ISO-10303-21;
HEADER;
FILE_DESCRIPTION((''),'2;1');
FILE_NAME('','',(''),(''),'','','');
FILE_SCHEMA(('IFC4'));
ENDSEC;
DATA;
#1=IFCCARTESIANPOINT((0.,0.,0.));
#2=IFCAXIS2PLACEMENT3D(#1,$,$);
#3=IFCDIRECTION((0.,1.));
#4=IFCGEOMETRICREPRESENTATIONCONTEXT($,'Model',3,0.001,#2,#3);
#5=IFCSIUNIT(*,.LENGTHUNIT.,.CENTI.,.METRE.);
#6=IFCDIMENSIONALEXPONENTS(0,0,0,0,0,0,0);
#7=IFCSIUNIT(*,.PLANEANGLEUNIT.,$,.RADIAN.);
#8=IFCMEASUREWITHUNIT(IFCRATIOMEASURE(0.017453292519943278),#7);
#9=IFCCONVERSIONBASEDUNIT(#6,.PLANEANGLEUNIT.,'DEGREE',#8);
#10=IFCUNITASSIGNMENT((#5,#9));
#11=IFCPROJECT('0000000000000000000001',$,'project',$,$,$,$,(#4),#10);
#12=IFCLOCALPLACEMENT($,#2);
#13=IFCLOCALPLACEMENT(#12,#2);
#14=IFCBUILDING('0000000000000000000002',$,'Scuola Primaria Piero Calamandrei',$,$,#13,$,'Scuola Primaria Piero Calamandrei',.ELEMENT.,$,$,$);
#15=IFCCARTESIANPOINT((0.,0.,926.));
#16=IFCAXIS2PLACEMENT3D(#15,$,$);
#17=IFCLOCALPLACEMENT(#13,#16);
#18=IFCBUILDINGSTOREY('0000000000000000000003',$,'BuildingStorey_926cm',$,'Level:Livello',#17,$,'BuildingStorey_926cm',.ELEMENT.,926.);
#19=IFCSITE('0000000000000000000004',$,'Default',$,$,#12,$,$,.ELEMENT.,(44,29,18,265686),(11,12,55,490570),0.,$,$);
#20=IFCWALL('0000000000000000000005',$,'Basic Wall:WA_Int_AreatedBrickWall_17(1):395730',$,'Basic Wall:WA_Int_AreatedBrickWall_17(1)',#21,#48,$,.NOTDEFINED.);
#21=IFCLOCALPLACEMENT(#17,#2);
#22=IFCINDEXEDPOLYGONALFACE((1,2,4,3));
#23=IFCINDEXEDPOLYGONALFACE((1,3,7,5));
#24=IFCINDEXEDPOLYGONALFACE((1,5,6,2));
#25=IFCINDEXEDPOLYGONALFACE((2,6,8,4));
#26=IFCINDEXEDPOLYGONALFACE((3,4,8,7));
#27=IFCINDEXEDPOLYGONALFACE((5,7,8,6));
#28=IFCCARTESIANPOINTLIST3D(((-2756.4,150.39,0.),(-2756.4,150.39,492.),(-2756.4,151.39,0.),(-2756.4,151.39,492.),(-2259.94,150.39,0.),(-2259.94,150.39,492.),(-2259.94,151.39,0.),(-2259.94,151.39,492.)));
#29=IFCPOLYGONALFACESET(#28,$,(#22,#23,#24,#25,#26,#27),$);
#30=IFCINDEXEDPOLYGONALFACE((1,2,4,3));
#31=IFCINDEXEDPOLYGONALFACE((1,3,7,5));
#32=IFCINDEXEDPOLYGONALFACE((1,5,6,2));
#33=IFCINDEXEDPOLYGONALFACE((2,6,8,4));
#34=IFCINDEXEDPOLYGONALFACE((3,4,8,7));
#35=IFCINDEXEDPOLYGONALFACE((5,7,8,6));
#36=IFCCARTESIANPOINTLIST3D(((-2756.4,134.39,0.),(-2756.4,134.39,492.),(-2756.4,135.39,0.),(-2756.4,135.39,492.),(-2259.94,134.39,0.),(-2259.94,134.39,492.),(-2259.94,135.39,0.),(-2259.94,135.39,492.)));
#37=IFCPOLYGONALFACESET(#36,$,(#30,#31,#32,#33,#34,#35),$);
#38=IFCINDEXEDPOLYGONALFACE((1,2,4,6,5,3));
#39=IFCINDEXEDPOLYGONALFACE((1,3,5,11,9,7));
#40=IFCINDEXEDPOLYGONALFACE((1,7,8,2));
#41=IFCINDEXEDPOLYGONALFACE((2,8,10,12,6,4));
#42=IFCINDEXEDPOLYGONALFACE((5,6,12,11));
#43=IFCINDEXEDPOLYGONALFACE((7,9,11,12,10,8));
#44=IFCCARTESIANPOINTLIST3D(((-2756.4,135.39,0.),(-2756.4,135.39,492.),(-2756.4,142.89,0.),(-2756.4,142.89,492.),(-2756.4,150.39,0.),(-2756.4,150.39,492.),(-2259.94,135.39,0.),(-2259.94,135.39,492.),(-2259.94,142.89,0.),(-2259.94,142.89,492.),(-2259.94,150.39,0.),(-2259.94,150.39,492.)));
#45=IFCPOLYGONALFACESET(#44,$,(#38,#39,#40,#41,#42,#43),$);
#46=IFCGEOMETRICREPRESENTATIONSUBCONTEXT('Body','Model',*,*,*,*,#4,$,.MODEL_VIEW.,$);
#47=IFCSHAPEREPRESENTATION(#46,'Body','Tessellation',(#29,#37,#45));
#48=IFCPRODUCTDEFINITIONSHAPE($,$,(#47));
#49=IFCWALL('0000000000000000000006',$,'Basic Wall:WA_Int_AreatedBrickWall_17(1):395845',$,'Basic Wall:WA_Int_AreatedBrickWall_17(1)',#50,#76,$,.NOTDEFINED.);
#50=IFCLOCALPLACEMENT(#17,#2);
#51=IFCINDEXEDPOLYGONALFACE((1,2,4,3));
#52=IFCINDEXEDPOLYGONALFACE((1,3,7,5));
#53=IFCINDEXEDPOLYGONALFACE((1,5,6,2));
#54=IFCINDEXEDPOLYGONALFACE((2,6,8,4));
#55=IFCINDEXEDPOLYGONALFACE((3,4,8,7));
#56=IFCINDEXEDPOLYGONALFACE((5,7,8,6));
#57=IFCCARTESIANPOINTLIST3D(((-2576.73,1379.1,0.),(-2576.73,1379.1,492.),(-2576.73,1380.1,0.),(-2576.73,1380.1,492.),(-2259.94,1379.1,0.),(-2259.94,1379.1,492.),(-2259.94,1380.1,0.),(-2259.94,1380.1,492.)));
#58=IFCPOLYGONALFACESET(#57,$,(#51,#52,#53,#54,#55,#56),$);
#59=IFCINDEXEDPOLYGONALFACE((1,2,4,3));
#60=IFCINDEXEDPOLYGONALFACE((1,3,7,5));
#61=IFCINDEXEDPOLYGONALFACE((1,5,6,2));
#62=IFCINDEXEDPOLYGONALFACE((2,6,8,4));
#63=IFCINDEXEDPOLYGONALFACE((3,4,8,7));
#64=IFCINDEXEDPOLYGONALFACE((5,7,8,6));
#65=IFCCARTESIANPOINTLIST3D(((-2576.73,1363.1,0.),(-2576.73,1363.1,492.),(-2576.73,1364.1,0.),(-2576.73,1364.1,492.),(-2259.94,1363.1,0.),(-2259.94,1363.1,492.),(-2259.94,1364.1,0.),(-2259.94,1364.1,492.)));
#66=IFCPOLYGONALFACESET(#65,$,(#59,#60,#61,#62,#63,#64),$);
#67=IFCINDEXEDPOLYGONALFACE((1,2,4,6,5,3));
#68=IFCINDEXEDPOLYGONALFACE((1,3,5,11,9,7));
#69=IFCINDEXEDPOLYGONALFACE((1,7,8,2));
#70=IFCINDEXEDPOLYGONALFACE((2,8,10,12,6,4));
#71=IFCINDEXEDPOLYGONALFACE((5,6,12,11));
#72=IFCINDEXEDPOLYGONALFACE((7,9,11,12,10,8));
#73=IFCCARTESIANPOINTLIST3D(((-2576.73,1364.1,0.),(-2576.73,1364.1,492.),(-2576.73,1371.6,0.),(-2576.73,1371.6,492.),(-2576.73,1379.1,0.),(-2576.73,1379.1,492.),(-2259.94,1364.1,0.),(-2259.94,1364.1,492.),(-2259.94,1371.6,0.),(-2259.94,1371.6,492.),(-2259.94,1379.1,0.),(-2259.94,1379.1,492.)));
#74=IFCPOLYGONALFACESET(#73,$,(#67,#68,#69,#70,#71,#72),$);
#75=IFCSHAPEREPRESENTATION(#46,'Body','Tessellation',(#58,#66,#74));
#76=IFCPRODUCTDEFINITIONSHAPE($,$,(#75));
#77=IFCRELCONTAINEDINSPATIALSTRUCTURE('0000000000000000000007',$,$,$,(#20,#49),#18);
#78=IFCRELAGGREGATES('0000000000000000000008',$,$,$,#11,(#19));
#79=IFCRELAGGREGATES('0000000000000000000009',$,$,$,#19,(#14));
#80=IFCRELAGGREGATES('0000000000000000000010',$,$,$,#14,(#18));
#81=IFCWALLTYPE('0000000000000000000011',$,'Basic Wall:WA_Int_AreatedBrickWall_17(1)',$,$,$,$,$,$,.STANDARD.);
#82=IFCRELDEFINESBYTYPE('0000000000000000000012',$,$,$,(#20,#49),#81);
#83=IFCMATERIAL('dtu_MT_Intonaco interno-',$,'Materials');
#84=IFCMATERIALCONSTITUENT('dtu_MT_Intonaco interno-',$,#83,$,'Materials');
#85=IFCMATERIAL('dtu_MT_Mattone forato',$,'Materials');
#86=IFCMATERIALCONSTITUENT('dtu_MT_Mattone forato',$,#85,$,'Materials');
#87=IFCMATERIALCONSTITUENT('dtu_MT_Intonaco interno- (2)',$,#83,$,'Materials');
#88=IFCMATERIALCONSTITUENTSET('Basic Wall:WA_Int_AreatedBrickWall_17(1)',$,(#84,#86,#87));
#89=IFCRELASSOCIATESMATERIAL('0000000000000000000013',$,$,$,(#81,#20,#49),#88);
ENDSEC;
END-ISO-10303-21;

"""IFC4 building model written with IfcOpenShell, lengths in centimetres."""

from ifc_helpers import new_model, entity, si_unit, converted_unit, direction, frame, origin, place, context, subcontext, project, spatial, indexed_curve, outline, extrude, material, constituent, constituent_set, type_object, element, save


model = new_model("IFC4")

# Units and contexts
model_context = context("Model", 3, precision=0.001, world=origin(), true_north=direction((0.0, 1.0)))
body_context = subcontext(model_context, "Body", "Model", "MODEL_VIEW")
ifc_project = project(units=[si_unit("LENGTHUNIT", "METRE", prefix="CENTI"), converted_unit("PLANEANGLEUNIT", "DEGREE", entity("IfcRatioMeasure", 0.017453292519943278), si_unit("PLANEANGLEUNIT", "RADIAN"), dimensions=[0, 0, 0, 0, 0, 0, 0])], contexts=[model_context])

# Site, building, storey
site_placement = place(None, origin())
site = spatial("IfcSite", under=ifc_project, at=site_placement, Name="Default", CompositionType="ELEMENT", RefLatitude=(44, 29, 18, 265686), RefLongitude=(11, 12, 55, 490570), RefElevation=0.0)
building_placement = place(site_placement, origin())
building = spatial("IfcBuilding", under=site, at=building_placement, Name="Scuola Primaria Piero Calamandrei", LongName="Scuola Primaria Piero Calamandrei", CompositionType="ELEMENT")
storey_placement = place(building_placement, frame((0.0, 0.0, 926.0)))
storey = spatial("IfcBuildingStorey", under=building, at=storey_placement, Name="BuildingStorey_926cm", ObjectType="Level:Livello", LongName="BuildingStorey_926cm", CompositionType="ELEMENT", Elevation=926.0)

# Shared definitions
ifc_material_1 = material(Name="dtu_MT_Intonaco interno-", Category="Materials")

# Walls
ifc_constituent_1 = constituent(ifc_material_1, Name="dtu_MT_Intonaco interno-", Category="Materials")
ifc_material_2 = material(Name="dtu_MT_Mattone forato", Category="Materials")
ifc_constituent_2 = constituent(ifc_material_2, Name="dtu_MT_Mattone forato", Category="Materials")
ifc_constituent_3 = constituent(ifc_material_1, Name="dtu_MT_Intonaco interno- (2)", Category="Materials")
ifc_constituent_set_1 = constituent_set(constituents=[ifc_constituent_1, ifc_constituent_2, ifc_constituent_3], Name="Basic Wall:WA_Int_AreatedBrickWall_17(1)")
wall_type_1 = type_object("IfcWallType", Name="Basic Wall:WA_Int_AreatedBrickWall_17(1)", PredefinedType="STANDARD", material=ifc_constituent_set_1)
wall_1_placement = place(storey_placement, frame((-2259.94, 142.89, 0.0), z_axis=(0.0, 0.0, 1.0), x_axis=(-1.0, 0.0, 0.0)))
element("IfcWall", 1, at=wall_1_placement, inside=storey, type_object=wall_type_1, material=ifc_constituent_set_1, Name="Basic Wall:WA_Int_AreatedBrickWall_17(1):395730", ObjectType="Basic Wall:WA_Int_AreatedBrickWall_17(1)", PredefinedType="NOTDEFINED", context=body_context, shape_type="SweptSolid", body=[
    extrude(outline(indexed_curve([(-0.5, -248.23), (0.5, -248.23), (0.5, 248.23), (-0.5, 248.23), (-0.5, -248.23)], self_intersect=False)), frame((248.23, -8.0, 0.0), z_axis=(0.0, 0.0, 1.0), x_axis=(0.0, 1.0, 0.0)), (0.0, 0.0, 1.0), 492.0),
    extrude(outline(indexed_curve([(-0.5, -248.23), (0.5, -248.23), (0.5, 248.23), (-0.5, 248.23), (-0.5, -248.23)], self_intersect=False)), frame((248.23, 8.0, 0.0), z_axis=(0.0, 0.0, 1.0), x_axis=(0.0, -1.0, 0.0)), (0.0, 0.0, 1.0), 492.0),
    extrude(outline(indexed_curve([(-248.23, -7.5), (248.23, -7.5), (248.23, 0.0), (248.23, 7.5), (-248.23, 7.5), (-248.23, 0.0), (-248.23, -7.5)], self_intersect=False)), frame((248.23, 0.0, 0.0)), (0.0, 0.0, 1.0), 492.0),
])
wall_2_placement = place(storey_placement, frame((-2259.94, 1371.6, 0.0), z_axis=(0.0, 0.0, 1.0), x_axis=(-1.0, 0.0, 0.0)))
element("IfcWall", 2, at=wall_2_placement, inside=storey, type_object=wall_type_1, material=ifc_constituent_set_1, Name="Basic Wall:WA_Int_AreatedBrickWall_17(1):395845", ObjectType="Basic Wall:WA_Int_AreatedBrickWall_17(1)", PredefinedType="NOTDEFINED", context=body_context, shape_type="SweptSolid", body=[
    extrude(outline(indexed_curve([(-0.5, -158.4), (0.5, -158.4), (0.5, 158.4), (-0.5, 158.4), (-0.5, -158.4)], self_intersect=False)), frame((158.4, -8.0, 0.0), z_axis=(0.0, 0.0, 1.0), x_axis=(0.0, 1.0, 0.0)), (0.0, 0.0, 1.0), 492.0),
    extrude(outline(indexed_curve([(-0.5, -158.4), (0.5, -158.4), (0.5, 158.4), (-0.5, 158.4), (-0.5, -158.4)], self_intersect=False)), frame((158.4, 8.0, 0.0), z_axis=(0.0, 0.0, 1.0), x_axis=(0.0, -1.0, 0.0)), (0.0, 0.0, 1.0), 492.0),
    extrude(outline(indexed_curve([(-158.4, -7.5), (158.4, -7.5), (158.4, 0.0), (158.4, 7.5), (-158.4, 7.5), (-158.4, 0.0), (-158.4, -7.5)], self_intersect=False)), frame((158.4, 0.0, 0.0)), (0.0, 0.0, 1.0), 492.0),
])

save(model, "model.ifc")
